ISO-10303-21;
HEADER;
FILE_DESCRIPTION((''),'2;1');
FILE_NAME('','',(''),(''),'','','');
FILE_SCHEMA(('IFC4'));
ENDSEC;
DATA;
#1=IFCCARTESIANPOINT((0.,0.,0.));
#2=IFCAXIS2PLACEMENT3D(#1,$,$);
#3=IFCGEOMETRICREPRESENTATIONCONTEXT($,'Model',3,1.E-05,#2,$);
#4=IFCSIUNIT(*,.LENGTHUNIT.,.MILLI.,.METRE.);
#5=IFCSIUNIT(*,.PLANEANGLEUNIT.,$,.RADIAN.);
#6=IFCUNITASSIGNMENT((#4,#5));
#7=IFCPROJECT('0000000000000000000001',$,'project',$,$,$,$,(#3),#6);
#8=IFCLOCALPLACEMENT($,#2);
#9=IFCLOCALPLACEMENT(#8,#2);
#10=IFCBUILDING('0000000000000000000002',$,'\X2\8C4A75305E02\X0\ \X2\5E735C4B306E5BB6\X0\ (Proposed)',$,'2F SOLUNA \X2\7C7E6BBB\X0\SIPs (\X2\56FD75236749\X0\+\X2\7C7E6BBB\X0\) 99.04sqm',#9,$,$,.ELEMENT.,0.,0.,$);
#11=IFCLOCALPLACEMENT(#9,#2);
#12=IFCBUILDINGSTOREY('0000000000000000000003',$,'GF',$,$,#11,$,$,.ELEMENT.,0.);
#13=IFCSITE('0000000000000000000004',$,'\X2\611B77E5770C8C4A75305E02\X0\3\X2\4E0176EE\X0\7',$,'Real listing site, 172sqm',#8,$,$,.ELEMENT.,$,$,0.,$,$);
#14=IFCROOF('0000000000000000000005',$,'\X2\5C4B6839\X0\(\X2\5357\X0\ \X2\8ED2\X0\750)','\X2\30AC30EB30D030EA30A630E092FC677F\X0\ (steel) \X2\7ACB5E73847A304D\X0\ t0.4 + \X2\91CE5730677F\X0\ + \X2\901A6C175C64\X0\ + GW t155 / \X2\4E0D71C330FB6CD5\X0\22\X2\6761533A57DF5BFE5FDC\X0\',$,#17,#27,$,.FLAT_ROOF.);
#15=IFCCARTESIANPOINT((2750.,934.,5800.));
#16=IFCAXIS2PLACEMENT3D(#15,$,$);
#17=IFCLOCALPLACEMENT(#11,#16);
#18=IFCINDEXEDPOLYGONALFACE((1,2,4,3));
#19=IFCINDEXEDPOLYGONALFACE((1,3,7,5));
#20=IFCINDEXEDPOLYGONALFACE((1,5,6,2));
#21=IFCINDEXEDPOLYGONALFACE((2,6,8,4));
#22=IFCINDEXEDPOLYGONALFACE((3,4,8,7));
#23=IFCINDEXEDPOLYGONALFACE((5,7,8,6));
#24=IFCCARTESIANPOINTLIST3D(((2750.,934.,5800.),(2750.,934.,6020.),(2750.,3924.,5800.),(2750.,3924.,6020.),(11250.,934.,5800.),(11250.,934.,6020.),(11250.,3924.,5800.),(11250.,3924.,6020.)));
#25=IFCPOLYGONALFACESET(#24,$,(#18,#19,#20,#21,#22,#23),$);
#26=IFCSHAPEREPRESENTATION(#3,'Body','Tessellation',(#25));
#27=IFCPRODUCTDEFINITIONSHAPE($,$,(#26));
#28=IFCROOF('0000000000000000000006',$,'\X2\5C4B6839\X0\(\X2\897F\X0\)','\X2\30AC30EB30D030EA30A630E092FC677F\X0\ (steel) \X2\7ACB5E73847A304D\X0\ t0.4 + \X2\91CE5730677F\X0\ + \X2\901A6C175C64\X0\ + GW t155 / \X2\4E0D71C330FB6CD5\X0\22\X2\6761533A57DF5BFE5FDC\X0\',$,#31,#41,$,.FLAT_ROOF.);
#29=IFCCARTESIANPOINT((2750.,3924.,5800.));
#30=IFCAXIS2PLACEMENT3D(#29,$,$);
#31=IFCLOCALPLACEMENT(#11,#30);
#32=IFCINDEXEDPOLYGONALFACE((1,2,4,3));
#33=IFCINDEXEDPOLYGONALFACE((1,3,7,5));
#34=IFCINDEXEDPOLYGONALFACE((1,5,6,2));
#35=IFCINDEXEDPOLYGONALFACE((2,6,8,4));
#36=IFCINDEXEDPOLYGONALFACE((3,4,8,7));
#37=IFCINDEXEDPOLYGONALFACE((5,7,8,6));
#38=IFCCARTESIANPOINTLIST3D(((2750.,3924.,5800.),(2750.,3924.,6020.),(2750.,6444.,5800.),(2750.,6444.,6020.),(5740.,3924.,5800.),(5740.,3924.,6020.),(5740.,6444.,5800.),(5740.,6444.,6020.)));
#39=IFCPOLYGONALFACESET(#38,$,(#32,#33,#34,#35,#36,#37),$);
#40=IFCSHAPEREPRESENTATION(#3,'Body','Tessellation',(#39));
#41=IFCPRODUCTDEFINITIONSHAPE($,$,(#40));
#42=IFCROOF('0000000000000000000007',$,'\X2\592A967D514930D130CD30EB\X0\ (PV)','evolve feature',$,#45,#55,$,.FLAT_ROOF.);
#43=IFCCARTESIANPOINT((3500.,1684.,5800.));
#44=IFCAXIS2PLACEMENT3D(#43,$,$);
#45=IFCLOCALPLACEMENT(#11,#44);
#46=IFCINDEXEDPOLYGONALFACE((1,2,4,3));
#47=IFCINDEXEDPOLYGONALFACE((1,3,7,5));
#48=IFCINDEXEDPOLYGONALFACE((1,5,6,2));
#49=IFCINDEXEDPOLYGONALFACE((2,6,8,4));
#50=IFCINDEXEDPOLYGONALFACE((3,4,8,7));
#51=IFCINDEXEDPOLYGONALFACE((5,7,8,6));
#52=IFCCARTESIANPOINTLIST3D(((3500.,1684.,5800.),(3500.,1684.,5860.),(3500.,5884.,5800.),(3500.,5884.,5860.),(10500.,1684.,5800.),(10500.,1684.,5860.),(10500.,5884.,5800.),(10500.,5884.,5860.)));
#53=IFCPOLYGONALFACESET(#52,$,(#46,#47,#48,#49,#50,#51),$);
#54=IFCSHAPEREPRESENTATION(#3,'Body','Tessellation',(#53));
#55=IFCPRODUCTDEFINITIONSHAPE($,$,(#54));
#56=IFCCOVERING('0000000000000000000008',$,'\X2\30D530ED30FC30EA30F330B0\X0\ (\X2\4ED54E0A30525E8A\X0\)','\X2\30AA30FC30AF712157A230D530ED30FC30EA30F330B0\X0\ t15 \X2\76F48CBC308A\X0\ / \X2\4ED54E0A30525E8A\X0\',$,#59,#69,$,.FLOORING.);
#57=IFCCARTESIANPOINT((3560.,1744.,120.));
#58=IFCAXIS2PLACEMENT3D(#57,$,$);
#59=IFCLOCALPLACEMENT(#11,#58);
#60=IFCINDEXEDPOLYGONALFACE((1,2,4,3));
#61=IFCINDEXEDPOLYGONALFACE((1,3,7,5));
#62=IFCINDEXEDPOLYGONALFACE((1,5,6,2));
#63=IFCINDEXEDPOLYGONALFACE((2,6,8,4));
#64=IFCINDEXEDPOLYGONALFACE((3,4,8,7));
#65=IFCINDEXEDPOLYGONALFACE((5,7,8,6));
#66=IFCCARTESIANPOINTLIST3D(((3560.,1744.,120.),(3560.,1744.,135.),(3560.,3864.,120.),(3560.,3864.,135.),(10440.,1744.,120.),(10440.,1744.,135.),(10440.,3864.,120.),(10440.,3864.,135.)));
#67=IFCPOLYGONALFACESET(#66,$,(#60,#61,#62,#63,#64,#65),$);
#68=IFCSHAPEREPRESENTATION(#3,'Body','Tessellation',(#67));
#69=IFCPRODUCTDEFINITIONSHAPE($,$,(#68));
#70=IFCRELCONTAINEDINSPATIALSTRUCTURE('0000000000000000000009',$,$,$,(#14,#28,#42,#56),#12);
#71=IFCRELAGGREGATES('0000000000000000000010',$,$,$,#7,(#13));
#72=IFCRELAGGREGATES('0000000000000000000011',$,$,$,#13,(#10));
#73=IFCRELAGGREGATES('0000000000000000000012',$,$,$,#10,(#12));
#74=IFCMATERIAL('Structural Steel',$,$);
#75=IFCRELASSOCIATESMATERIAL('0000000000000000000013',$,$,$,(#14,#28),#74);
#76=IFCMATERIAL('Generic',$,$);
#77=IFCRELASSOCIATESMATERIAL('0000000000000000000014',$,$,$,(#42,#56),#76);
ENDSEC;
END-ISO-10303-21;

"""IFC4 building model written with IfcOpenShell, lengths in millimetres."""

from ifc_helpers import new_model, si_unit, frame, frame_2d, origin, place, context, project, spatial, rectangle, extrude, material, element, save


model = new_model("IFC4")

# Units and contexts
model_context = context("Model", 3, precision=1e-05, world=origin())
ifc_project = project(units=[si_unit("LENGTHUNIT", "METRE", prefix="MILLI"), si_unit("PLANEANGLEUNIT", "RADIAN")], contexts=[model_context])

# Site, building, storey
site_placement = place(None, origin())
site = spatial("IfcSite", under=ifc_project, at=site_placement, Name="愛知県豊田市3丁目7", ObjectType="Real listing site, 172sqm", CompositionType="ELEMENT", RefElevation=0.0)
building_placement = place(site_placement, origin())
building = spatial("IfcBuilding", under=site, at=building_placement, Name="豊田市 平屋の家 (Proposed)", ObjectType="2F SOLUNA 籾殻SIPs (国産杉+籾殻) 99.04sqm", CompositionType="ELEMENT", ElevationOfRefHeight=0.0, ElevationOfTerrain=0.0)
storey_placement = place(building_placement, origin())
storey = spatial("IfcBuildingStorey", under=building, at=storey_placement, Name="GF", CompositionType="ELEMENT", Elevation=0.0)

# Shared definitions
ifc_material_1 = material(Name="Generic")

# Roofs
ifc_material_2 = material(Name="Structural Steel")
roof_1_placement = place(storey_placement, frame((2750.0, 934.0, 5800.0)))
element("IfcRoof", 1, at=roof_1_placement, inside=storey, material=ifc_material_2, Name="屋根(南 軒750)", Description="ガルバリウム鋼板 (steel) 立平葺き t0.4 + 野地板 + 通気層 + GW t155 / 不燃・法22条区域対応", PredefinedType="FLAT_ROOF", context=model_context, shape_type="SweptSolid", body=[
    extrude(rectangle(XDim=8500.0, YDim=2990.0, at=frame_2d((4250.0, 1495.0))), frame((2750.0, 934.0, 5800.0)), (0.0, 0.0, 1.0), 220.0),
])
roof_2_placement = place(storey_placement, frame((2750.0, 3924.0, 5800.0)))
element("IfcRoof", 2, at=roof_2_placement, inside=storey, material=ifc_material_2, Name="屋根(西)", Description="ガルバリウム鋼板 (steel) 立平葺き t0.4 + 野地板 + 通気層 + GW t155 / 不燃・法22条区域対応", PredefinedType="FLAT_ROOF", context=model_context, shape_type="SweptSolid", body=[
    extrude(rectangle(XDim=2990.0, YDim=2520.0, at=frame_2d((1495.0, 1260.0))), frame((2750.0, 3924.0, 5800.0)), (0.0, 0.0, 1.0), 220.0),
])
roof_3_placement = place(storey_placement, frame((3500.0, 1684.0, 5800.0)))
element("IfcRoof", 3, at=roof_3_placement, inside=storey, material=ifc_material_1, Name="太陽光パネル (PV)", Description="evolve feature", PredefinedType="FLAT_ROOF", context=model_context, shape_type="SweptSolid", body=[
    extrude(rectangle(XDim=7000.0, YDim=4200.0, at=frame_2d((3500.0, 2100.0))), frame((3500.0, 1684.0, 5800.0)), (0.0, 0.0, 1.0), 60.0),
])

# Covering
covering_placement = place(storey_placement, frame((3560.0, 1744.0, 120.0)))
element("IfcCovering", 4, at=covering_placement, inside=storey, material=ifc_material_1, Name="フローリング (仕上げ床)", Description="オーク無垢フローリング t15 直貼り / 仕上げ床", PredefinedType="FLOORING", context=model_context, shape_type="SweptSolid", body=[
    extrude(rectangle(XDim=6880.0, YDim=2120.0, at=frame_2d((3440.0, 1060.0))), frame((3560.0, 1744.0, 120.0)), (0.0, 0.0, 1.0), 15.0),
])

save(model, "model.ifc")
